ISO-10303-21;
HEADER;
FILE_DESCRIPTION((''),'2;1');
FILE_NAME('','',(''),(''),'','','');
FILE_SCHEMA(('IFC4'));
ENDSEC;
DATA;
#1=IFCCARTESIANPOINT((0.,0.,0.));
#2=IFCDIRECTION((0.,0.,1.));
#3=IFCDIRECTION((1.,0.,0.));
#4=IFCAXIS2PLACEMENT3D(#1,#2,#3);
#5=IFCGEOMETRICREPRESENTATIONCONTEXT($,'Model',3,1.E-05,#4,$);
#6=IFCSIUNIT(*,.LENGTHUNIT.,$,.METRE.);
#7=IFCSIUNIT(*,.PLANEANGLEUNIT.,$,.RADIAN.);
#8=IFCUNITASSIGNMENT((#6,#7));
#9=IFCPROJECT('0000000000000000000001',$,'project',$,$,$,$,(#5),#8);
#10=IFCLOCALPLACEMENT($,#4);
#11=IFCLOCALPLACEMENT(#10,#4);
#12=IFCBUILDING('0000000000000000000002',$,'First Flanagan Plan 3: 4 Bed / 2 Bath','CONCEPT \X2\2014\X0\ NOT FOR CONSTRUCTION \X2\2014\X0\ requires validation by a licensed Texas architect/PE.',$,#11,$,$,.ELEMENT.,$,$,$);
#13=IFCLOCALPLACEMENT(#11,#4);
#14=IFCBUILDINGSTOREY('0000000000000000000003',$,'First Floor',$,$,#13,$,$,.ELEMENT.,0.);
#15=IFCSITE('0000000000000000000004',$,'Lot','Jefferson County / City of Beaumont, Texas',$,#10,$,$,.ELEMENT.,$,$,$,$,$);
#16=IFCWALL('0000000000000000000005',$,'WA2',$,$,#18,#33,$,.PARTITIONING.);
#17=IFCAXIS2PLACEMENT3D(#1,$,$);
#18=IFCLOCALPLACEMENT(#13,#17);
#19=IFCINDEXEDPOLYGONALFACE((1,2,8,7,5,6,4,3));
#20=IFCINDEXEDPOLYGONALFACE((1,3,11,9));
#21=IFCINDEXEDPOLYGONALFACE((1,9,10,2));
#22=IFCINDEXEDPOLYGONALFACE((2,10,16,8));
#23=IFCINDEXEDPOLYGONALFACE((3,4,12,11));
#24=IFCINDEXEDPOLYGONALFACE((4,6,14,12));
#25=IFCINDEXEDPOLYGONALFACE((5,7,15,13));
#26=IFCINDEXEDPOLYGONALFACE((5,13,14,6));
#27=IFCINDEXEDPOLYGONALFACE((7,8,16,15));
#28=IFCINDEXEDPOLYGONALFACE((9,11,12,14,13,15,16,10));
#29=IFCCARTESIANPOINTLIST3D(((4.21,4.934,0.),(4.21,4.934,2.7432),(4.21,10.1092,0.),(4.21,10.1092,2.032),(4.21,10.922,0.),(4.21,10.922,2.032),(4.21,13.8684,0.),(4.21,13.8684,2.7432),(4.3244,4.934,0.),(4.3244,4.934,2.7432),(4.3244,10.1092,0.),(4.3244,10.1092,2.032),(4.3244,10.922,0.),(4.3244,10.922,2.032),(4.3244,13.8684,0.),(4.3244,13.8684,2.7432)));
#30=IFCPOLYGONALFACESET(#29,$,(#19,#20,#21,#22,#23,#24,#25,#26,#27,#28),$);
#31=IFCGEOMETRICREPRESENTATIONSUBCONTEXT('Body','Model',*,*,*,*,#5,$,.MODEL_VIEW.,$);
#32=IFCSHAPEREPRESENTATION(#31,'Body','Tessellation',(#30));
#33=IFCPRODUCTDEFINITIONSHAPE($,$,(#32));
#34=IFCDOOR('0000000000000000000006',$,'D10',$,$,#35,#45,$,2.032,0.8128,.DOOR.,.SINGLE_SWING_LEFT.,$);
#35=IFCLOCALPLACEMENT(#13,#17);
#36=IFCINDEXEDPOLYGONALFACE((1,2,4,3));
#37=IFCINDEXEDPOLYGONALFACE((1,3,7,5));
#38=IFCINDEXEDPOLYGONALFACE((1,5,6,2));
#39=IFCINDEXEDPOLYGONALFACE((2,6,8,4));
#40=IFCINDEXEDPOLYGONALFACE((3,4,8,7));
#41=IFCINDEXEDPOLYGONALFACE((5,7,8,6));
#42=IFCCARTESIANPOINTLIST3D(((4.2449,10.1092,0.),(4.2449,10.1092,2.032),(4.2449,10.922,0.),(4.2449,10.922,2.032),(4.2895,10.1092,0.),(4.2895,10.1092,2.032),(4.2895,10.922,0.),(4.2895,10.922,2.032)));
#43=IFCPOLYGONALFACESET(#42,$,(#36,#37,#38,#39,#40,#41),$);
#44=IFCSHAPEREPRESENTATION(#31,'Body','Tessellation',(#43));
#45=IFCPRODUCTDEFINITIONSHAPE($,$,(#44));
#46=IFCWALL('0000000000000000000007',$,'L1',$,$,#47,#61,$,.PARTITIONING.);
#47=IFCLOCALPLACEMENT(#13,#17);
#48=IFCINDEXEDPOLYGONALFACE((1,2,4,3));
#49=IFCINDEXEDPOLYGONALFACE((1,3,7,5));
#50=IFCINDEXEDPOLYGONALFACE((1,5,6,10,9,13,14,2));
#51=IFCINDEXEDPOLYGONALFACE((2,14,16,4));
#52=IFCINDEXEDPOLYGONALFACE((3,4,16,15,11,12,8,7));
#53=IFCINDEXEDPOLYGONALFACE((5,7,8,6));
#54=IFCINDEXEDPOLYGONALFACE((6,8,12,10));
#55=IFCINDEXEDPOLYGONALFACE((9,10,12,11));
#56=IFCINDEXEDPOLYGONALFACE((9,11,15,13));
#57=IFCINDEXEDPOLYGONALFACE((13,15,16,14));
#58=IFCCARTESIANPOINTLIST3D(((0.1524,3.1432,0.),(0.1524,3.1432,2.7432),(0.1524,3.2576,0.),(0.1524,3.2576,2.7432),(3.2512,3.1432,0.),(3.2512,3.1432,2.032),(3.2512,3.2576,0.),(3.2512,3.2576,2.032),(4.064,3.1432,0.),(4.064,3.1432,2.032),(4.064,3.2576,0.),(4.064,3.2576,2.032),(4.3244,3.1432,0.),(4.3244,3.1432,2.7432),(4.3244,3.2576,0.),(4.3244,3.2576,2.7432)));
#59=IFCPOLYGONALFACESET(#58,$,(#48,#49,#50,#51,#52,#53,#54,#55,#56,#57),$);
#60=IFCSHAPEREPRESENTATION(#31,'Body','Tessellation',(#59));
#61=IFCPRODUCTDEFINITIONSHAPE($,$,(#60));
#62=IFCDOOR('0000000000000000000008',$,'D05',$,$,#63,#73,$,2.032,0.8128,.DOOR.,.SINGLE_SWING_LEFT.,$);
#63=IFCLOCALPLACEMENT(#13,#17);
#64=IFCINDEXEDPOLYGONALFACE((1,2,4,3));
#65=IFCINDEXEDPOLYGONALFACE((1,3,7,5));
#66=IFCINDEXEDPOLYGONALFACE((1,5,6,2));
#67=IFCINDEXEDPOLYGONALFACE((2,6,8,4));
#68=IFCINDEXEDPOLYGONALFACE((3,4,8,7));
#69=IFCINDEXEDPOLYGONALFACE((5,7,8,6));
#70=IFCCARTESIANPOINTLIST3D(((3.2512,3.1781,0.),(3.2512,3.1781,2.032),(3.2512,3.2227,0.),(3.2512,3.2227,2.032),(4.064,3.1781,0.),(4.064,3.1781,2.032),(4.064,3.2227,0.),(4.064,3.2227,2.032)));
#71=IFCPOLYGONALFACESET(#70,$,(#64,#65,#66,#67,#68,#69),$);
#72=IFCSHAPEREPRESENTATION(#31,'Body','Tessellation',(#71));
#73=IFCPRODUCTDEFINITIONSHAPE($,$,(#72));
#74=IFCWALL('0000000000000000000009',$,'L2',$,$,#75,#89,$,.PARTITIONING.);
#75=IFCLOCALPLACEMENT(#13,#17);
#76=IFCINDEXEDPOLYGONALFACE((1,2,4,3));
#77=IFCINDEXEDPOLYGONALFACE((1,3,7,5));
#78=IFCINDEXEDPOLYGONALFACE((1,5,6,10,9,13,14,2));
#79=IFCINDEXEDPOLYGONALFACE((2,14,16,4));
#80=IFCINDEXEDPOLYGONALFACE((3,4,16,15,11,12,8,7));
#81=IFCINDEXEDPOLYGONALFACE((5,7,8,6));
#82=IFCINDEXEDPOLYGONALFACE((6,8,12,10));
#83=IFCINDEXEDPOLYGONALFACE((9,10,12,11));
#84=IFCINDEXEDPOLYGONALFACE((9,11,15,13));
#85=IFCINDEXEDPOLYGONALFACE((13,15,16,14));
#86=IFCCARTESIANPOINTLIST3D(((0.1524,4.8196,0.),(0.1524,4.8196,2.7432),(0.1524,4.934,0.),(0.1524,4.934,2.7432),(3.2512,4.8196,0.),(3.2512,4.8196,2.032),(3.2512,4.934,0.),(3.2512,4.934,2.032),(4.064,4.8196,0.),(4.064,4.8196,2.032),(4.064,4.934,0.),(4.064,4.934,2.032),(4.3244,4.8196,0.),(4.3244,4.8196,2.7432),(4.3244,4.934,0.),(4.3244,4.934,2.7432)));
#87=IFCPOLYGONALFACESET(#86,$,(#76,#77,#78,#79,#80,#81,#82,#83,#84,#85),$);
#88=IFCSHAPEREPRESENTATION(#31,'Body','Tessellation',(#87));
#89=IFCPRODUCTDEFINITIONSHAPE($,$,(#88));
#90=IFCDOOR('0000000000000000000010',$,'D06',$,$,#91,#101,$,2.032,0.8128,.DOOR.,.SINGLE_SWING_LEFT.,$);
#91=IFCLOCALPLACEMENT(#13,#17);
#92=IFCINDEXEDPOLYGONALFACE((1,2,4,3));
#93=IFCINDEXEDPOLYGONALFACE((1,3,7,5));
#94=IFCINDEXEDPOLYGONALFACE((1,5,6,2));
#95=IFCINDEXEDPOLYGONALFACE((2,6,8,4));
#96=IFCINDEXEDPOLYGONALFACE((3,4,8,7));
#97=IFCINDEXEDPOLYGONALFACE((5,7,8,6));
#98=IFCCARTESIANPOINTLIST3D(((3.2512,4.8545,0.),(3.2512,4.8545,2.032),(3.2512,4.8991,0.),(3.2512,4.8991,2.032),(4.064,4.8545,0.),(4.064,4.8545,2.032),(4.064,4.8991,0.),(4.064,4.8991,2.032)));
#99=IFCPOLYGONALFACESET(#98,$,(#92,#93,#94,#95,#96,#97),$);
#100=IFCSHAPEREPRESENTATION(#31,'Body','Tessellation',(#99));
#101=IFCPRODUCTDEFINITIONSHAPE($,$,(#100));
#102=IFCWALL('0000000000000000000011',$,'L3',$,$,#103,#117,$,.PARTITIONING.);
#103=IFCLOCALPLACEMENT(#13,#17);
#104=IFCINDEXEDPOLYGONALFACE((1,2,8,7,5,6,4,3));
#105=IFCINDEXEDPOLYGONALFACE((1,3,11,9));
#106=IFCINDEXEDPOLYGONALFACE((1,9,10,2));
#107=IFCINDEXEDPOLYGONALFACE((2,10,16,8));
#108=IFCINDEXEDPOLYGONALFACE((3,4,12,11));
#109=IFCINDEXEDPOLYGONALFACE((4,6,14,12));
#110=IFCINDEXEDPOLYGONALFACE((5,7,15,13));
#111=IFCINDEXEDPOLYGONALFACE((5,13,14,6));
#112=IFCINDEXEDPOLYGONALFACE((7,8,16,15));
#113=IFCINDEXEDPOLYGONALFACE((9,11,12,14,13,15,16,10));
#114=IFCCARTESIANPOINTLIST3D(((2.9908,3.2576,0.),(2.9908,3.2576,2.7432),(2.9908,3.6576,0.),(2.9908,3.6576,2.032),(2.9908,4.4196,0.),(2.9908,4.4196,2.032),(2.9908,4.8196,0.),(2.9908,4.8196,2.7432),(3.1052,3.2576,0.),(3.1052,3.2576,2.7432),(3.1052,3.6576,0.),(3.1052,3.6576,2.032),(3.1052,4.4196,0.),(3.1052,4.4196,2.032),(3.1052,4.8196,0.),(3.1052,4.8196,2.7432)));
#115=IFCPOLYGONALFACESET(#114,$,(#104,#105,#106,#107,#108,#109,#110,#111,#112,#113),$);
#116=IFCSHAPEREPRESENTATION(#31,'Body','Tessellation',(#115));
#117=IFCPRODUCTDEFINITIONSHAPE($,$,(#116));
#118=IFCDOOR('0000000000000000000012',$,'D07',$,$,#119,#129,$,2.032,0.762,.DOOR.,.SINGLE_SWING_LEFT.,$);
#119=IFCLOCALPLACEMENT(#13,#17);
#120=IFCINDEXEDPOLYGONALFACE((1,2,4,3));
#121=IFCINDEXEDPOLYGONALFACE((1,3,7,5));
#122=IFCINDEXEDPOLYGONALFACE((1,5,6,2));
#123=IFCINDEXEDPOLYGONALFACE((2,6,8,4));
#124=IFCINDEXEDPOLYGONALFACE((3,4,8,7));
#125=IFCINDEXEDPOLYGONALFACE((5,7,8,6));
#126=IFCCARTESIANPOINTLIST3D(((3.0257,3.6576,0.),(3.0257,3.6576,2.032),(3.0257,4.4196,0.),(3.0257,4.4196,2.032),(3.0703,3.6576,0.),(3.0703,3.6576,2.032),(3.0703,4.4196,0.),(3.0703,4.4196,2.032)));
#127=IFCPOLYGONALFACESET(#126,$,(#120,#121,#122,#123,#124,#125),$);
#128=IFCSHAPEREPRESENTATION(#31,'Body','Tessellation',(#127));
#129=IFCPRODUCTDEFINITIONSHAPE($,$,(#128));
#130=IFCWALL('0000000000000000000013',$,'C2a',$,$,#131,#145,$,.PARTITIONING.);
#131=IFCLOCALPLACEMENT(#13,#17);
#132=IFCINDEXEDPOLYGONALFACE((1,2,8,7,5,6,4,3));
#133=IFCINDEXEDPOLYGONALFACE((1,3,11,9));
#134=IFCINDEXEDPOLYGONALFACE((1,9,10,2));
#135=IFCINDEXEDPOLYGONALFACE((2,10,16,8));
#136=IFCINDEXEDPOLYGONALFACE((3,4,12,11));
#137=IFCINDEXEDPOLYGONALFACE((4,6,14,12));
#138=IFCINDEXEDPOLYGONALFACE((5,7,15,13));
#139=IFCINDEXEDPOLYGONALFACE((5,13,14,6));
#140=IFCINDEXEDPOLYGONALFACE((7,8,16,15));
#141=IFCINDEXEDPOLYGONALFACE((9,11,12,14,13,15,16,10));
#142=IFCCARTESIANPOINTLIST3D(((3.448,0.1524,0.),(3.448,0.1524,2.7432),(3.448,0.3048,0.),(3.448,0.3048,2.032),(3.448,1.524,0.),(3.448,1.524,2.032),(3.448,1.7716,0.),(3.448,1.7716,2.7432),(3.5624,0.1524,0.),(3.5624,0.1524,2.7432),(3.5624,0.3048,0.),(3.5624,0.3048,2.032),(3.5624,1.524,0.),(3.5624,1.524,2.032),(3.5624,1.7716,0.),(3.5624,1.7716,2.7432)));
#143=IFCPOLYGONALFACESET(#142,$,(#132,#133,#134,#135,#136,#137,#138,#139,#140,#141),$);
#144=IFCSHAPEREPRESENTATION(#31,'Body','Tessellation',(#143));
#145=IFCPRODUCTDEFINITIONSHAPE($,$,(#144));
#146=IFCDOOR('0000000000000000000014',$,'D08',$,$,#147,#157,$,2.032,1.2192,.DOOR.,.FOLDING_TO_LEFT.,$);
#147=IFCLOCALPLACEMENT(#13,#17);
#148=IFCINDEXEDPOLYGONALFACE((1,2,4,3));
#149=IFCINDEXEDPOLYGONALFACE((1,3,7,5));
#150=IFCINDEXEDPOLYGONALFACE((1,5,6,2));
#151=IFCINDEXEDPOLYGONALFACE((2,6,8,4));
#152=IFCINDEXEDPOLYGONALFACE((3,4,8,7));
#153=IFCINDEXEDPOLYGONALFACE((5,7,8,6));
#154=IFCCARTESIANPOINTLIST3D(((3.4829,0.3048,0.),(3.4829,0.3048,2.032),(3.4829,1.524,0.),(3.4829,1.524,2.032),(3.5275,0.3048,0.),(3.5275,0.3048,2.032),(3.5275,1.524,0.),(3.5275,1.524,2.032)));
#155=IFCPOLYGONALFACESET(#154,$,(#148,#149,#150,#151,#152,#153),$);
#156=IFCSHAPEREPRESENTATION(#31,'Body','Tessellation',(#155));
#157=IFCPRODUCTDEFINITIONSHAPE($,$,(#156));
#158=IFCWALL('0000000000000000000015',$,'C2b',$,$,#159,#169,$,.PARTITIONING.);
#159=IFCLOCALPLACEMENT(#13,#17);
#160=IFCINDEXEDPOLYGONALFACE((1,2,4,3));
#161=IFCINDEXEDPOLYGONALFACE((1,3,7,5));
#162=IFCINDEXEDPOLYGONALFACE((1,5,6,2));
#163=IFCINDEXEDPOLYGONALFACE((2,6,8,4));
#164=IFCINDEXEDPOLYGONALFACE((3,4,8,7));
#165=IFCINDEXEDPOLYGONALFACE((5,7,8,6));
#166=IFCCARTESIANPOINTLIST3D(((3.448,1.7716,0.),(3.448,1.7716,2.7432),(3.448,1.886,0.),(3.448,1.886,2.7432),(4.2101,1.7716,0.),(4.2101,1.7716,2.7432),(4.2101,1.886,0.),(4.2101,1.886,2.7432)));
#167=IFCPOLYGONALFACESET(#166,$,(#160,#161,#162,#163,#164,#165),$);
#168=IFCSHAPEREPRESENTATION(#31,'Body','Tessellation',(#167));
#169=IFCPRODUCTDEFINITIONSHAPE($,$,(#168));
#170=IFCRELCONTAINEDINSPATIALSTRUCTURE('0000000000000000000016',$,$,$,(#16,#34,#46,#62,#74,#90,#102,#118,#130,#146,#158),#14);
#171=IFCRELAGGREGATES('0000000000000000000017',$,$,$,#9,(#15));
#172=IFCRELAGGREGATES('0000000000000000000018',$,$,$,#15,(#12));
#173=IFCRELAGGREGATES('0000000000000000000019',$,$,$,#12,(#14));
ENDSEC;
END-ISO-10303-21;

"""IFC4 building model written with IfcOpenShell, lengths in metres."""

from ifc_helpers import new_model, si_unit, frame, frame_2d, origin_with_axes, place, context, subcontext, project, spatial, rectangle, extrude, element, fill, save


model = new_model("IFC4")

# Units and contexts
model_context = context("Model", 3, precision=1e-05, world=origin_with_axes())
body_context = subcontext(model_context, "Body", "Model", "MODEL_VIEW")
ifc_project = project(units=[si_unit("LENGTHUNIT", "METRE"), si_unit("PLANEANGLEUNIT", "RADIAN")], contexts=[model_context])

# Site, building, storey
site_placement = place(None, origin_with_axes())
site = spatial("IfcSite", under=ifc_project, at=site_placement, Name="Lot", Description="Jefferson County / City of Beaumont, Texas", CompositionType="ELEMENT")
building_placement = place(site_placement, origin_with_axes())
building = spatial("IfcBuilding", under=site, at=building_placement, Name="First Flanagan Plan 3: 4 Bed / 2 Bath", Description="CONCEPT — NOT FOR CONSTRUCTION — requires validation by a licensed Texas architect/PE.", CompositionType="ELEMENT")
storey_placement = place(building_placement, origin_with_axes())
storey = spatial("IfcBuildingStorey", under=building, at=storey_placement, Name="First Floor", CompositionType="ELEMENT", Elevation=0.0)

# Walls, openings, doors
wall_1_placement = place(storey_placement, frame((4.2672, 4.934, 0.0), z_axis=(0.0, 0.0, 1.0), x_axis=(0.0, 1.0, 0.0)))
wall_1 = element("IfcWall", 1, at=wall_1_placement, inside=storey, Name="WA2", PredefinedType="PARTITIONING", context=body_context, shape_type="SweptSolid", body=[
    extrude(rectangle(XDim=8.9345, YDim=0.1143, at=frame_2d((4.4672, 0.0), x_axis=(1.0, 0.0))), origin_with_axes(), (0.0, 0.0, 1.0), 2.7432),
])
opening_1_placement = place(wall_1_placement, frame((5.1752, 0.0, 0.0), z_axis=(0.0, 0.0, 1.0), x_axis=(1.0, 0.0, 0.0)))
opening_1 = element("IfcOpeningElement", 2, at=opening_1_placement, cuts=wall_1, PredefinedType="OPENING", context=body_context, shape_type="SweptSolid", body=[
    extrude(rectangle(XDim=0.8128, YDim=0.1448, at=frame_2d((0.4064, 0.0), x_axis=(1.0, 0.0))), origin_with_axes(), (0.0, 0.0, 1.0), 2.032),
])
door_1_placement = place(opening_1_placement, origin_with_axes())
door_1 = element("IfcDoor", 3, at=door_1_placement, inside=storey, Name="D10", OperationType="SINGLE_SWING_LEFT", OverallHeight=2.032, OverallWidth=0.8128, PredefinedType="DOOR", context=body_context, shape_type="SweptSolid", body=[
    extrude(rectangle(XDim=0.8128, YDim=0.0445, at=frame_2d((0.4064, 0.0), x_axis=(1.0, 0.0))), origin_with_axes(), (0.0, 0.0, 1.0), 2.032),
])
fill(opening_1, door_1)
wall_2_placement = place(storey_placement, frame((0.1524, 3.2004, 0.0), z_axis=(0.0, 0.0, 1.0), x_axis=(1.0, 0.0, 0.0)))
wall_2 = element("IfcWall", 4, at=wall_2_placement, inside=storey, Name="L1", PredefinedType="PARTITIONING", context=body_context, shape_type="SweptSolid", body=[
    extrude(rectangle(XDim=4.1719, YDim=0.1143, at=frame_2d((2.086, 0.0), x_axis=(1.0, 0.0))), origin_with_axes(), (0.0, 0.0, 1.0), 2.7432),
])
opening_2_placement = place(wall_2_placement, frame((3.0988, 0.0, 0.0), z_axis=(0.0, 0.0, 1.0), x_axis=(1.0, 0.0, 0.0)))
opening_2 = element("IfcOpeningElement", 5, at=opening_2_placement, cuts=wall_2, PredefinedType="OPENING", context=body_context, shape_type="SweptSolid", body=[
    extrude(rectangle(XDim=0.8128, YDim=0.1448, at=frame_2d((0.4064, 0.0), x_axis=(1.0, 0.0))), origin_with_axes(), (0.0, 0.0, 1.0), 2.032),
])
door_2_placement = place(opening_2_placement, origin_with_axes())
door_2 = element("IfcDoor", 6, at=door_2_placement, inside=storey, Name="D05", OperationType="SINGLE_SWING_LEFT", OverallHeight=2.032, OverallWidth=0.8128, PredefinedType="DOOR", context=body_context, shape_type="SweptSolid", body=[
    extrude(rectangle(XDim=0.8128, YDim=0.0445, at=frame_2d((0.4064, 0.0), x_axis=(1.0, 0.0))), origin_with_axes(), (0.0, 0.0, 1.0), 2.032),
])
fill(opening_2, door_2)
wall_3_placement = place(storey_placement, frame((0.1524, 4.8768, 0.0), z_axis=(0.0, 0.0, 1.0), x_axis=(1.0, 0.0, 0.0)))
wall_3 = element("IfcWall", 7, at=wall_3_placement, inside=storey, Name="L2", PredefinedType="PARTITIONING", context=body_context, shape_type="SweptSolid", body=[
    extrude(rectangle(XDim=4.1719, YDim=0.1143, at=frame_2d((2.086, 0.0), x_axis=(1.0, 0.0))), origin_with_axes(), (0.0, 0.0, 1.0), 2.7432),
])
opening_3_placement = place(wall_3_placement, frame((3.0988, 0.0, 0.0), z_axis=(0.0, 0.0, 1.0), x_axis=(1.0, 0.0, 0.0)))
opening_3 = element("IfcOpeningElement", 8, at=opening_3_placement, cuts=wall_3, PredefinedType="OPENING", context=body_context, shape_type="SweptSolid", body=[
    extrude(rectangle(XDim=0.8128, YDim=0.1448, at=frame_2d((0.4064, 0.0), x_axis=(1.0, 0.0))), origin_with_axes(), (0.0, 0.0, 1.0), 2.032),
])
door_3_placement = place(opening_3_placement, origin_with_axes())
door_3 = element("IfcDoor", 9, at=door_3_placement, inside=storey, Name="D06", OperationType="SINGLE_SWING_LEFT", OverallHeight=2.032, OverallWidth=0.8128, PredefinedType="DOOR", context=body_context, shape_type="SweptSolid", body=[
    extrude(rectangle(XDim=0.8128, YDim=0.0445, at=frame_2d((0.4064, 0.0), x_axis=(1.0, 0.0))), origin_with_axes(), (0.0, 0.0, 1.0), 2.032),
])
fill(opening_3, door_3)
wall_4_placement = place(storey_placement, frame((3.048, 3.2576, 0.0), z_axis=(0.0, 0.0, 1.0), x_axis=(0.0, 1.0, 0.0)))
wall_4 = element("IfcWall", 10, at=wall_4_placement, inside=storey, Name="L3", PredefinedType="PARTITIONING", context=body_context, shape_type="SweptSolid", body=[
    extrude(rectangle(XDim=1.5621, YDim=0.1143, at=frame_2d((0.7811, 0.0), x_axis=(1.0, 0.0))), origin_with_axes(), (0.0, 0.0, 1.0), 2.7432),
])
opening_4_placement = place(wall_4_placement, frame((0.4001, 0.0, 0.0), z_axis=(0.0, 0.0, 1.0), x_axis=(1.0, 0.0, 0.0)))
opening_4 = element("IfcOpeningElement", 11, at=opening_4_placement, cuts=wall_4, PredefinedType="OPENING", context=body_context, shape_type="SweptSolid", body=[
    extrude(rectangle(XDim=0.762, YDim=0.1448, at=frame_2d((0.381, 0.0), x_axis=(1.0, 0.0))), origin_with_axes(), (0.0, 0.0, 1.0), 2.032),
])
door_4_placement = place(opening_4_placement, origin_with_axes())
door_4 = element("IfcDoor", 12, at=door_4_placement, inside=storey, Name="D07", OperationType="SINGLE_SWING_LEFT", OverallHeight=2.032, OverallWidth=0.762, PredefinedType="DOOR", context=body_context, shape_type="SweptSolid", body=[
    extrude(rectangle(XDim=0.762, YDim=0.0445, at=frame_2d((0.381, 0.0), x_axis=(1.0, 0.0))), origin_with_axes(), (0.0, 0.0, 1.0), 2.032),
])
fill(opening_4, door_4)
wall_5_placement = place(storey_placement, frame((3.5052, 0.1524, 0.0), z_axis=(0.0, 0.0, 1.0), x_axis=(0.0, 1.0, 0.0)))
wall_5 = element("IfcWall", 13, at=wall_5_placement, inside=storey, Name="C2a", PredefinedType="PARTITIONING", context=body_context, shape_type="SweptSolid", body=[
    extrude(rectangle(XDim=1.6193, YDim=0.1143, at=frame_2d((0.8096, 0.0), x_axis=(1.0, 0.0))), origin_with_axes(), (0.0, 0.0, 1.0), 2.7432),
])
opening_5_placement = place(wall_5_placement, frame((0.1524, 0.0, 0.0), z_axis=(0.0, 0.0, 1.0), x_axis=(1.0, 0.0, 0.0)))
opening_5 = element("IfcOpeningElement", 14, at=opening_5_placement, cuts=wall_5, PredefinedType="OPENING", context=body_context, shape_type="SweptSolid", body=[
    extrude(rectangle(XDim=1.2192, YDim=0.1448, at=frame_2d((0.6096, 0.0), x_axis=(1.0, 0.0))), origin_with_axes(), (0.0, 0.0, 1.0), 2.032),
])
door_5_placement = place(opening_5_placement, origin_with_axes())
door_5 = element("IfcDoor", 15, at=door_5_placement, inside=storey, Name="D08", OperationType="FOLDING_TO_LEFT", OverallHeight=2.032, OverallWidth=1.2192, PredefinedType="DOOR", context=body_context, shape_type="SweptSolid", body=[
    extrude(rectangle(XDim=1.2192, YDim=0.0445, at=frame_2d((0.6096, 0.0), x_axis=(1.0, 0.0))), origin_with_axes(), (0.0, 0.0, 1.0), 2.032),
])
fill(opening_5, door_5)

# Wall
wall_6_placement = place(storey_placement, frame((3.4481, 1.8288, 0.0), z_axis=(0.0, 0.0, 1.0), x_axis=(1.0, 0.0, 0.0)))
element("IfcWall", 16, at=wall_6_placement, inside=storey, Name="C2b", PredefinedType="PARTITIONING", context=body_context, shape_type="SweptSolid", body=[
    extrude(rectangle(XDim=0.762, YDim=0.1143, at=frame_2d((0.381, 0.0), x_axis=(1.0, 0.0))), origin_with_axes(), (0.0, 0.0, 1.0), 2.7432),
])

save(model, "model.ifc")
